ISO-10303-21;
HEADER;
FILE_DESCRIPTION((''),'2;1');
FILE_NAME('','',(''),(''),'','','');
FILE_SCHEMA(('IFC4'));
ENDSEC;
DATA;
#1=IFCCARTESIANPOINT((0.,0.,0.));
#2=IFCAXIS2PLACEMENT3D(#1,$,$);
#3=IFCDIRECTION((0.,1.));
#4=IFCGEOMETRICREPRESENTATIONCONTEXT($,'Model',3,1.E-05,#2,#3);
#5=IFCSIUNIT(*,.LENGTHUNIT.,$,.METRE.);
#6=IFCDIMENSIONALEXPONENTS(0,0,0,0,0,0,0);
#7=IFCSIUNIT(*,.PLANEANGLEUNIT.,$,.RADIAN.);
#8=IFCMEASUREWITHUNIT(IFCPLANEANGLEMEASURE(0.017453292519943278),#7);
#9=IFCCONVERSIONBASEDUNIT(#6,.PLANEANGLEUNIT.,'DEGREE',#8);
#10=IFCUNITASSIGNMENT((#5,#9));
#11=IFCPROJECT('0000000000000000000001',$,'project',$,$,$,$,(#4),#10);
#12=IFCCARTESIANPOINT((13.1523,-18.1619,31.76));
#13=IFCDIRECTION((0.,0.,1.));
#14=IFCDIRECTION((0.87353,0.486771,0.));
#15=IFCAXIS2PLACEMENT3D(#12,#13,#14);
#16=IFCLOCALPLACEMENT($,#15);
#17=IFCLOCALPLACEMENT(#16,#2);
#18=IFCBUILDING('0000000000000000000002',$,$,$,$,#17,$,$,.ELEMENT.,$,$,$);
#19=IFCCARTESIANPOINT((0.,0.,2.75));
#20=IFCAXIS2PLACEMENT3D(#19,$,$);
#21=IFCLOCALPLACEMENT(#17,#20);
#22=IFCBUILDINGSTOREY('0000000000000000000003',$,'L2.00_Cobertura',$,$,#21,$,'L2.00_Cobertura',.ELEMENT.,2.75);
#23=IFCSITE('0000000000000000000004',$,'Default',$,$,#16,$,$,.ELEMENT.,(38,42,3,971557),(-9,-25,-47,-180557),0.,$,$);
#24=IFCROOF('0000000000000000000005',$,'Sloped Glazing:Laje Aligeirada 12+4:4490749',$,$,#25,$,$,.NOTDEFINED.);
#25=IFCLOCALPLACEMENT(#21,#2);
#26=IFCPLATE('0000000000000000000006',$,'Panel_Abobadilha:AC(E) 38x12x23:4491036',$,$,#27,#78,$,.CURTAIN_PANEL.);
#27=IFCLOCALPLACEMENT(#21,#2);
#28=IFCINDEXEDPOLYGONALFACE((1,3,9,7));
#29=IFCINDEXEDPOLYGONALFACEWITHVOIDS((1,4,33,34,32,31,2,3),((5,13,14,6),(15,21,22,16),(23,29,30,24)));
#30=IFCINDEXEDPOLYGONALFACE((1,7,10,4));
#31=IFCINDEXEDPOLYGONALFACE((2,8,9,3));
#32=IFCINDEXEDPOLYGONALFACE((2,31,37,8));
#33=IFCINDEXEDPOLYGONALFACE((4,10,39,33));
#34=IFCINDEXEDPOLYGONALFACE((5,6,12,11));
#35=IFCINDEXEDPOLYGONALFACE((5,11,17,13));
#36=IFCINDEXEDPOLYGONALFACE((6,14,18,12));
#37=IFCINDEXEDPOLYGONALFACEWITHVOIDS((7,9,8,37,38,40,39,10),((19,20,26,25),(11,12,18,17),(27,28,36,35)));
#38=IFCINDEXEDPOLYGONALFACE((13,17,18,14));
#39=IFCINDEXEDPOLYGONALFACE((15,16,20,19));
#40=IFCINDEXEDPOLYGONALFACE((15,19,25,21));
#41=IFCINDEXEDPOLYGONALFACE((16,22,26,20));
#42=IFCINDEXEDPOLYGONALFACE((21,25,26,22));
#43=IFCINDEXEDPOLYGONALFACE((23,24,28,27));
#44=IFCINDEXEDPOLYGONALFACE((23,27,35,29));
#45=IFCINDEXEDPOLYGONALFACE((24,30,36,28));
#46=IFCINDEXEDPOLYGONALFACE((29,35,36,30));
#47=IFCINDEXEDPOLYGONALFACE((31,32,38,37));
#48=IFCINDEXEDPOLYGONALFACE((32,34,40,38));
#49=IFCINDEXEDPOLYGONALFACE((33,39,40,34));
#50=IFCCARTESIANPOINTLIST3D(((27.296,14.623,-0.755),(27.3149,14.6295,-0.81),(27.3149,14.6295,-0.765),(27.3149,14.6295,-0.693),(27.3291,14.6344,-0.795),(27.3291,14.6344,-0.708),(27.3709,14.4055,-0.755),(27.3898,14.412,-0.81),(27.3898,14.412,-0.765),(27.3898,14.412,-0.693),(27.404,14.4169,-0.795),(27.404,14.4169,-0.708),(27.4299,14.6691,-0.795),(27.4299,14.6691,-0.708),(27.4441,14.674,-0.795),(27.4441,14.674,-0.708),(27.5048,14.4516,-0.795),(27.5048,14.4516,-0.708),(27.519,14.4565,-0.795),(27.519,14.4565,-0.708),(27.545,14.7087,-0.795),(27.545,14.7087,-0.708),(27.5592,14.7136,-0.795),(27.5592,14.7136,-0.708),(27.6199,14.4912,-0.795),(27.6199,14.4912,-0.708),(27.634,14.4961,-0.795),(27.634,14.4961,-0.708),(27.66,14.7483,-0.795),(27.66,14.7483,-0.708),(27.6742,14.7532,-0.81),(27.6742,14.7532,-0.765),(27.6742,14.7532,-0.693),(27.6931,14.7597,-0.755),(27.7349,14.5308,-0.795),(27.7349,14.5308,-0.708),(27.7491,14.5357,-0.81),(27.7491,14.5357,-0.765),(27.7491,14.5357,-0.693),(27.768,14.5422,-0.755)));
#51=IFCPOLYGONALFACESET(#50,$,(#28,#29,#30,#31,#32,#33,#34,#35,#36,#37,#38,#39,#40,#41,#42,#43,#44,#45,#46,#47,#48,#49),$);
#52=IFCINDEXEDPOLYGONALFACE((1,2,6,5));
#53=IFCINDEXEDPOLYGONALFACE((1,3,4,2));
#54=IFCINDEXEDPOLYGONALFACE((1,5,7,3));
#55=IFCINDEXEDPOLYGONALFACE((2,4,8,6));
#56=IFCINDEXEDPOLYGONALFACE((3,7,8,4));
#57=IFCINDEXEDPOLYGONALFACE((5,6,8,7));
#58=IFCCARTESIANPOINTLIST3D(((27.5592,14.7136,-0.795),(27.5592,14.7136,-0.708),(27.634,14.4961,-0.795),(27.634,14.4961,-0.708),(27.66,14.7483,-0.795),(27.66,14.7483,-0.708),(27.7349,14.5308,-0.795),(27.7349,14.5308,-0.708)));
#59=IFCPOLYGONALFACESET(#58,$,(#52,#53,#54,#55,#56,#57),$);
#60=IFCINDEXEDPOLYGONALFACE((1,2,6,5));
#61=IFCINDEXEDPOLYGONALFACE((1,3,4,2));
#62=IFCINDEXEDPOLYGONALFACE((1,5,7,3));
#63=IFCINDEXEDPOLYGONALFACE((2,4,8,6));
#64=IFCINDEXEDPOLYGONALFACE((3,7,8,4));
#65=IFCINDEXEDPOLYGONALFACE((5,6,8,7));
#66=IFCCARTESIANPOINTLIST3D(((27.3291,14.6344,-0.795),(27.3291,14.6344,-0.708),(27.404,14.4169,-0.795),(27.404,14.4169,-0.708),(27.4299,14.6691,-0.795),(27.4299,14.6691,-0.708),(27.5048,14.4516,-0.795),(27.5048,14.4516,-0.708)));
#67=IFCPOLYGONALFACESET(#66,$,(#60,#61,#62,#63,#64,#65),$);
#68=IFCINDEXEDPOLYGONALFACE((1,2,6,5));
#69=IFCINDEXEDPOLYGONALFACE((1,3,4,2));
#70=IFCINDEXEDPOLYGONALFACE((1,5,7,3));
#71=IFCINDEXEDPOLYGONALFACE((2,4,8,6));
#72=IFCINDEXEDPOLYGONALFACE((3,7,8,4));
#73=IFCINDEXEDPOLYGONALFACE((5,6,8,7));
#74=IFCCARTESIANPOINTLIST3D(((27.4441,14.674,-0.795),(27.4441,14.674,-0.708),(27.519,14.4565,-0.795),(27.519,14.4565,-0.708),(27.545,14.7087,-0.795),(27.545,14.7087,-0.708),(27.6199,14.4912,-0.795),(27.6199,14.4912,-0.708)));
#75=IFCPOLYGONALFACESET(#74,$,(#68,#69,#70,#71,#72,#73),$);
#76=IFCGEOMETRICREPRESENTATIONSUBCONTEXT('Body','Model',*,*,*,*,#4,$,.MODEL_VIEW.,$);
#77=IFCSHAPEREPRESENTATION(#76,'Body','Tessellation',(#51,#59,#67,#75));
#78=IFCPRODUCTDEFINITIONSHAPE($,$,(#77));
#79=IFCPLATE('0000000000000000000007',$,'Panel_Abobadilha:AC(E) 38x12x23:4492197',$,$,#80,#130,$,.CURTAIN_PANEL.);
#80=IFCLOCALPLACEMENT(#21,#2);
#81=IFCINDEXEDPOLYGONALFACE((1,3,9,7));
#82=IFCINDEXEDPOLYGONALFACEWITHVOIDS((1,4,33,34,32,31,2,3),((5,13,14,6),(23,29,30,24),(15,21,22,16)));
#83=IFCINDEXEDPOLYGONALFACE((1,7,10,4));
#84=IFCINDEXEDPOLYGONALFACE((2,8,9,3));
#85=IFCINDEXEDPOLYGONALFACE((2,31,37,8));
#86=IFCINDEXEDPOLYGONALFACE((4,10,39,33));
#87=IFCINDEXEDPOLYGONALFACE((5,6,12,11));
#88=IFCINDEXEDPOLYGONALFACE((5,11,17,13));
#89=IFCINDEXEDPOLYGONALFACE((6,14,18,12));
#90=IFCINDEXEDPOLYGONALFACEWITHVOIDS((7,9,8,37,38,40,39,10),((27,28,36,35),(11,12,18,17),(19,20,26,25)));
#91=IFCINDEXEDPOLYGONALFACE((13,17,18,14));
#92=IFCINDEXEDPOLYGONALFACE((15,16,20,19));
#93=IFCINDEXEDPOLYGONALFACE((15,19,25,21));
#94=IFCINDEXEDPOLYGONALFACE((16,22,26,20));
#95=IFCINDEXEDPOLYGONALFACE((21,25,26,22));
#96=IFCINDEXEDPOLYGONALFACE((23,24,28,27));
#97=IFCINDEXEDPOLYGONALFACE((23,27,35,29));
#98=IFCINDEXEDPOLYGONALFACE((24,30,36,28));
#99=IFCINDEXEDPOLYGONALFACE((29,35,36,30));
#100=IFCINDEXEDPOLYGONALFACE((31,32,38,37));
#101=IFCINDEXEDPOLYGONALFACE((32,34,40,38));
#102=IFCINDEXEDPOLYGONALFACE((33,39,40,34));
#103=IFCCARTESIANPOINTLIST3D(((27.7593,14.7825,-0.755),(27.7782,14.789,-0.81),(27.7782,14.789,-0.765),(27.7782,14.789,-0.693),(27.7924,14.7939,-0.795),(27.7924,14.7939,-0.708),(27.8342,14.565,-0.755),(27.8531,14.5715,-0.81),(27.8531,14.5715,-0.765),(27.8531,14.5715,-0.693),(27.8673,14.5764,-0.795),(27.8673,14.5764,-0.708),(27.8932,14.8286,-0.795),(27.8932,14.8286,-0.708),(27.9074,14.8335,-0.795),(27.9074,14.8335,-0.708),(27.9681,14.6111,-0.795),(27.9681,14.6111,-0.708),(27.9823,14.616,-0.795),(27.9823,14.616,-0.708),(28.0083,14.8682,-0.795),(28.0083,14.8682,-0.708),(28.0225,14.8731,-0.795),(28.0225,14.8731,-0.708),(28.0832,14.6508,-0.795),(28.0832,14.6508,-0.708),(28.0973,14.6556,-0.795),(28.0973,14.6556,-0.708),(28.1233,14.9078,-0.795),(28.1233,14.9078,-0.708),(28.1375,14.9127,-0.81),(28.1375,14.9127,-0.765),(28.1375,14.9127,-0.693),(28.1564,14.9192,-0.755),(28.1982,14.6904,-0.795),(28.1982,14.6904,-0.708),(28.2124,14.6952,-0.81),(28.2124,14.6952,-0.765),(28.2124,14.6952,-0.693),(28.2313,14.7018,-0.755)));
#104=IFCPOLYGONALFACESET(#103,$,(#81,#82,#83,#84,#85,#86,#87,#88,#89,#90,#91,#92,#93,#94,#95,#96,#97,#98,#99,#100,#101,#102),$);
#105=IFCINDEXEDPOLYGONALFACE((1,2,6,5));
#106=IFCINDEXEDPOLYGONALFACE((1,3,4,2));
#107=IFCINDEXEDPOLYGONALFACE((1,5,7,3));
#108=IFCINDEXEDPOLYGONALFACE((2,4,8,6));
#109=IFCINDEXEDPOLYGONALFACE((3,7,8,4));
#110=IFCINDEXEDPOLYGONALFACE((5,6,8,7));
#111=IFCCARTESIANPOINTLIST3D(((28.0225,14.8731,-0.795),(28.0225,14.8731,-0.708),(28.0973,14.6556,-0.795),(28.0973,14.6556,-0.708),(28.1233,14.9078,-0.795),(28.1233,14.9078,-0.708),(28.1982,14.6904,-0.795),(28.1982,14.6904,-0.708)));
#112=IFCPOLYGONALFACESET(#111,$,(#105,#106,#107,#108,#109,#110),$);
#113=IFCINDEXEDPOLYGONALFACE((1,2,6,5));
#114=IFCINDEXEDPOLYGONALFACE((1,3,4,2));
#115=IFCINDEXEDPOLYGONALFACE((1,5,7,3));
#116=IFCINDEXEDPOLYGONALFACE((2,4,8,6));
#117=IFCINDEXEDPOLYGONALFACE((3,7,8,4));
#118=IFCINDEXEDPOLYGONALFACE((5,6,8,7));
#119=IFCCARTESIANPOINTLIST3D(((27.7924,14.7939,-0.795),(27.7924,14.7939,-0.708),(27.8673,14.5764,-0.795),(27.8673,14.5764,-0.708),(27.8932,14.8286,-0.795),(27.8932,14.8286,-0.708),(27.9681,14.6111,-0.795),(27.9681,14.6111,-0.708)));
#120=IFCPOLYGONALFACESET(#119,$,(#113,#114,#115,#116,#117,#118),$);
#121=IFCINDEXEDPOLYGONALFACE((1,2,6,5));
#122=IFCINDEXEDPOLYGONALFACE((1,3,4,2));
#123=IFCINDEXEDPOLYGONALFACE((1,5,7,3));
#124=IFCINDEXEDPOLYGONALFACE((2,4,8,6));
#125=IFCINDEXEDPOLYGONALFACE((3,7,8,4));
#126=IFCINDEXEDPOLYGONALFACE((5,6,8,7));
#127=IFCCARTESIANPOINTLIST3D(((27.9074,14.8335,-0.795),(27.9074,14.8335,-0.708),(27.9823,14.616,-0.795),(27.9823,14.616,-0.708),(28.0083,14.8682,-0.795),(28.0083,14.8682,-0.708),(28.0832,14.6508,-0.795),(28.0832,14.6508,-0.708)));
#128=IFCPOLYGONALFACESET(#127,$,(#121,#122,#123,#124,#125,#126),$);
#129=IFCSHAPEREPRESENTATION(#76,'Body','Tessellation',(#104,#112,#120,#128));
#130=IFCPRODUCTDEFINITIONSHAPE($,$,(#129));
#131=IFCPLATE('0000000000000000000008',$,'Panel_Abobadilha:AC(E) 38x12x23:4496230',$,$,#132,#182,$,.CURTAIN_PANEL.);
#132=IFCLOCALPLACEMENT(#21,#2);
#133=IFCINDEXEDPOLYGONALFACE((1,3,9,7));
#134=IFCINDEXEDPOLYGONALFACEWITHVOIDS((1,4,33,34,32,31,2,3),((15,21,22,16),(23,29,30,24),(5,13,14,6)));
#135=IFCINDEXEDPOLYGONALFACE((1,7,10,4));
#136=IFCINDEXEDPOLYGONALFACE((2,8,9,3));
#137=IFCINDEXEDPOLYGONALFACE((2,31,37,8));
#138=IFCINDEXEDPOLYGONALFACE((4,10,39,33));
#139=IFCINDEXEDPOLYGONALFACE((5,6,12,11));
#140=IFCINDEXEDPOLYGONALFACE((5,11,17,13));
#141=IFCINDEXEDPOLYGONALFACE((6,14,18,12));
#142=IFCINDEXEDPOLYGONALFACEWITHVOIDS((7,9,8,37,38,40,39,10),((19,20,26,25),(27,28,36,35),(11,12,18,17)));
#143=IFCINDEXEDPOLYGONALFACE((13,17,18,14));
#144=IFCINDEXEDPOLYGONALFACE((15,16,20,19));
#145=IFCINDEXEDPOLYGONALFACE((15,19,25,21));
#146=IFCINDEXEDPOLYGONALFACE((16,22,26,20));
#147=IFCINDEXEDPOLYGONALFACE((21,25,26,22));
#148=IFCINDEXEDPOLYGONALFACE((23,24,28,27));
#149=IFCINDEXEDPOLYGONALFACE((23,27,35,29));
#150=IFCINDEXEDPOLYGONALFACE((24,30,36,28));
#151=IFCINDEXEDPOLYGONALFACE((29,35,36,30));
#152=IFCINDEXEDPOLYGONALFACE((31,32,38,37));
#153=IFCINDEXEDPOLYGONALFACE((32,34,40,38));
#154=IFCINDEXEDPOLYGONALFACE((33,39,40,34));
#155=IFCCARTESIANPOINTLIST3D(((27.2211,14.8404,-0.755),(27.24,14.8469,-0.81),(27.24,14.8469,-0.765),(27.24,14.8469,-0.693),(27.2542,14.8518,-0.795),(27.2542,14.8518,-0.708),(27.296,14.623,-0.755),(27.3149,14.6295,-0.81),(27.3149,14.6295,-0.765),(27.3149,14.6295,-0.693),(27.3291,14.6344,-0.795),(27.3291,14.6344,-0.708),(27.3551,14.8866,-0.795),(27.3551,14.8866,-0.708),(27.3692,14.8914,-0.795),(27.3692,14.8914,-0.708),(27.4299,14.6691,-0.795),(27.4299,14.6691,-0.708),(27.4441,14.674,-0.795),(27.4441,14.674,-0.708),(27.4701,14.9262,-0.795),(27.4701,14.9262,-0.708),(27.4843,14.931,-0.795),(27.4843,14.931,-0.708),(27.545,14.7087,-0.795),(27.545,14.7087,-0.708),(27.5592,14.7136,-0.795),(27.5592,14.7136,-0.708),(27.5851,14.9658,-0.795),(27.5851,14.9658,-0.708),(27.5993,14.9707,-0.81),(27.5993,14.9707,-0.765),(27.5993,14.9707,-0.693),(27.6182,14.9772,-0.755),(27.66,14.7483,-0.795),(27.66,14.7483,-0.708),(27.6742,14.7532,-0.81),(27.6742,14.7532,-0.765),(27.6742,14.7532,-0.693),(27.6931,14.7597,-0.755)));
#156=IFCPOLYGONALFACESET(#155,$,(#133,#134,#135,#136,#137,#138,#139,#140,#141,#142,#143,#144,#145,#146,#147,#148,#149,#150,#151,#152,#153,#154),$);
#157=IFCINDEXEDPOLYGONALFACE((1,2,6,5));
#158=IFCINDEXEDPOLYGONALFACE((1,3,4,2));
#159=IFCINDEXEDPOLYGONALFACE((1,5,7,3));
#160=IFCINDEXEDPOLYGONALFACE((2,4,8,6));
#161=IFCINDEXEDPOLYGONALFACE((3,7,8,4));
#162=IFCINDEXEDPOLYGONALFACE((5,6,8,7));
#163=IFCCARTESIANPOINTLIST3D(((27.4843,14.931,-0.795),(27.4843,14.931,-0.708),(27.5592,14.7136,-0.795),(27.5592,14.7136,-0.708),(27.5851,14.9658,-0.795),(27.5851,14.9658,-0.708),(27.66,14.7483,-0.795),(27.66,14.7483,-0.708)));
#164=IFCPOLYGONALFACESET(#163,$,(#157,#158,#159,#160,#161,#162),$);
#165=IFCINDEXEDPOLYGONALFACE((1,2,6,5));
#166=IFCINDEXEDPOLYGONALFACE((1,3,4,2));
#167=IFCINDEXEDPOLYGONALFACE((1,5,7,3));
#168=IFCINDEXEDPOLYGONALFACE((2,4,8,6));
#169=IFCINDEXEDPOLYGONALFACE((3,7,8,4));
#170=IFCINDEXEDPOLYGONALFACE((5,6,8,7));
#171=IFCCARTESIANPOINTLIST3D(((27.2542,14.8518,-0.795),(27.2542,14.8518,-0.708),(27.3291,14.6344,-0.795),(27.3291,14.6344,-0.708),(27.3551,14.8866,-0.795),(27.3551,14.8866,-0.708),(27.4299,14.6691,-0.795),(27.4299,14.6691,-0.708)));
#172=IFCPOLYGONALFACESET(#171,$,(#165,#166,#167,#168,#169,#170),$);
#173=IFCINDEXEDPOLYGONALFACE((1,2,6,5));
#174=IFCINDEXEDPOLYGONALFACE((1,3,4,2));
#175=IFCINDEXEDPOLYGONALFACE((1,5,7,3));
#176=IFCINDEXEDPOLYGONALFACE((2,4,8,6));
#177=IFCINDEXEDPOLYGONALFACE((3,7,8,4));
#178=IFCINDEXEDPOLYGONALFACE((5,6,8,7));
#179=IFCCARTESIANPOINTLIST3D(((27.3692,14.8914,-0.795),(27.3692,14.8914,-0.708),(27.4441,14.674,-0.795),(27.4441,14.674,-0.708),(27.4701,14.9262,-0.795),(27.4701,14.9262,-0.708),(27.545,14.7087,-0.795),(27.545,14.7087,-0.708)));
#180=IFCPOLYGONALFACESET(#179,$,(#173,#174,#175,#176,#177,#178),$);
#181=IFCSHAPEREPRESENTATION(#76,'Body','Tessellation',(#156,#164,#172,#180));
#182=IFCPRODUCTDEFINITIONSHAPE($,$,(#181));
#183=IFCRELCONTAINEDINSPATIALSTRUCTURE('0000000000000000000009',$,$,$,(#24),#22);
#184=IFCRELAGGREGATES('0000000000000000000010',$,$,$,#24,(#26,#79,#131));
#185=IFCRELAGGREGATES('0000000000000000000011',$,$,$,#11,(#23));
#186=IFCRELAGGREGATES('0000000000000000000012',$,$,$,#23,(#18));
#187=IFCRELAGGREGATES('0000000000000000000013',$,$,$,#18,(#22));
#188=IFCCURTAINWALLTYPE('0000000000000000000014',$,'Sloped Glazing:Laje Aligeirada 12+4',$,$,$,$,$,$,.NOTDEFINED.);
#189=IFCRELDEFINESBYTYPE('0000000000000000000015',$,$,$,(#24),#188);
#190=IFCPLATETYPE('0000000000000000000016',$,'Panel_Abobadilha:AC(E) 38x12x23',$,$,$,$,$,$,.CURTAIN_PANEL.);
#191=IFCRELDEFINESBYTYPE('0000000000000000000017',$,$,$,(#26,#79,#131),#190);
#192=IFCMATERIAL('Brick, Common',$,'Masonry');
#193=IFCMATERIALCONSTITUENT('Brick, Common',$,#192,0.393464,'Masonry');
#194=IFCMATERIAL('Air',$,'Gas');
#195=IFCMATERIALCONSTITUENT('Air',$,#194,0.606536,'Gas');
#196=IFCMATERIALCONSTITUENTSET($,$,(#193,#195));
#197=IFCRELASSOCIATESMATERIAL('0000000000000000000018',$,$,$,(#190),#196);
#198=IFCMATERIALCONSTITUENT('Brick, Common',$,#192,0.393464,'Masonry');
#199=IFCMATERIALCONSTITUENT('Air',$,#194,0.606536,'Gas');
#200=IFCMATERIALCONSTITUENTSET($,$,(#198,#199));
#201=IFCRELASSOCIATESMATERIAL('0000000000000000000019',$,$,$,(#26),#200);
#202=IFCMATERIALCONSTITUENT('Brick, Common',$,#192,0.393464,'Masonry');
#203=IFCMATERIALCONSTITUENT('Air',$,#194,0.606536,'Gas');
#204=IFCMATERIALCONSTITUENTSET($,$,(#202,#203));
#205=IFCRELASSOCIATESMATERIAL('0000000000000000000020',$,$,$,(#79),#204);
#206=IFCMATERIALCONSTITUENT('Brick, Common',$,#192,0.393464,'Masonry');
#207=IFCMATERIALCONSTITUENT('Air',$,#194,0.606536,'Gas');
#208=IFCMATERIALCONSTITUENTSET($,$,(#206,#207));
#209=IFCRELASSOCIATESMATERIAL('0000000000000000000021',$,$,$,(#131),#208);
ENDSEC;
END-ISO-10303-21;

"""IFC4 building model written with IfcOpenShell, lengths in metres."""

from ifc_helpers import new_model, entity, si_unit, converted_unit, direction, frame, origin, place, context, subcontext, project, spatial, indexed_curve, outline, extrude, source, transform, mapped, material, constituent, constituent_set, type_object, type_shapes, element, aggregate, save


model = new_model("IFC4")

# Units and contexts
model_context = context("Model", 3, precision=1e-05, world=origin(), true_north=direction((0.0, 1.0)))
body_context = subcontext(model_context, "Body", "Model", "MODEL_VIEW")
ifc_project = project(units=[si_unit("LENGTHUNIT", "METRE"), converted_unit("PLANEANGLEUNIT", "DEGREE", entity("IfcPlaneAngleMeasure", 0.017453292519943278), si_unit("PLANEANGLEUNIT", "RADIAN"), dimensions=[0, 0, 0, 0, 0, 0, 0])], contexts=[model_context])

# Site, building, storey
site_placement = place(None, frame((13.1523, -18.1619, 31.76), z_axis=(0.0, 0.0, 1.0), x_axis=(0.87353, 0.486771, 0.0)))
site = spatial("IfcSite", under=ifc_project, at=site_placement, Name="Default", CompositionType="ELEMENT", RefLatitude=(38, 42, 3, 971557), RefLongitude=(-9, -25, -47, -180557), RefElevation=0.0)
building_placement = place(site_placement, origin())
building = spatial("IfcBuilding", under=site, at=building_placement, CompositionType="ELEMENT")
storey_placement = place(building_placement, frame((0.0, 0.0, 2.75)))
storey = spatial("IfcBuildingStorey", under=building, at=storey_placement, Name="L2.00_Cobertura", LongName="L2.00_Cobertura", CompositionType="ELEMENT", Elevation=2.75)

# Roof, plates
curtain_wall_type = type_object("IfcCurtainWallType", Name="Sloped Glazing:Laje Aligeirada 12+4", PredefinedType="NOTDEFINED")
roof_placement = place(storey_placement, frame((0.0, 0.0, -2.75)))
roof = element("IfcRoof", 1, at=roof_placement, inside=storey, type_object=curtain_wall_type, Name="Sloped Glazing:Laje Aligeirada 12+4:4490749", PredefinedType="NOTDEFINED")
ifc_material_1 = material(Name="Brick, Common", Category="Masonry")
ifc_material_2 = material(Name="Air", Category="Gas")
ifc_constituent_1 = constituent(ifc_material_1, Name="Brick, Common", Category="Masonry", fraction=0.393464)
ifc_constituent_2 = constituent(ifc_material_2, Name="Air", Category="Gas", fraction=0.606536)
ifc_constituent_set_1 = constituent_set(constituents=[ifc_constituent_1, ifc_constituent_2])
plate_type = type_object("IfcPlateType", Name="Panel_Abobadilha:AC(E) 38x12x23", PredefinedType="CURTAIN_PANEL", material=ifc_constituent_set_1)
shared_shape_1 = source(origin(), body_context, "Body", "SweptSolid", [
    extrude(outline(indexed_curve([(-0.19, -0.0543), (0.19, -0.0543), (0.19, -0.0093), (0.21, 0.0007), (0.19, 0.0628), (-0.19, 0.0628), (-0.21, 0.0007), (-0.19, -0.0093), (-0.19, -0.0543)], self_intersect=False), holes=[indexed_curve([(-0.0683, 0.0477), (-0.0683, -0.0393), (-0.175, -0.0393), (-0.175, 0.0477), (-0.0683, 0.0477)], self_intersect=False), indexed_curve([(0.0533, 0.0477), (0.0533, -0.0393), (-0.0533, -0.0393), (-0.0533, 0.0477), (0.0533, 0.0477)], self_intersect=False), indexed_curve([(0.175, 0.0477), (0.175, -0.0393), (0.0683, -0.0393), (0.0683, 0.0477), (0.175, 0.0477)], self_intersect=False)]), frame((0.0, 0.0543, 0.0)), (0.0, 0.0, 1.0), 0.23),
    extrude(outline(indexed_curve([(-0.0533, -0.0435), (0.0533, -0.0435), (0.0533, 0.0435), (-0.0533, 0.0435), (-0.0533, -0.0435)], self_intersect=False)), frame((0.1217, 0.0585, 0.0), z_axis=(0.0, 0.0, 1.0), x_axis=(-1.0, 0.0, 0.0)), (0.0, 0.0, 1.0), 0.23),
    extrude(outline(indexed_curve([(-0.0533, -0.0435), (0.0533, -0.0435), (0.0533, 0.0435), (-0.0533, 0.0435), (-0.0533, -0.0435)], self_intersect=False)), frame((-0.1217, 0.0585, 0.0), z_axis=(0.0, 0.0, 1.0), x_axis=(-1.0, 0.0, 0.0)), (0.0, 0.0, 1.0), 0.23),
    extrude(outline(indexed_curve([(-0.0533, -0.0435), (0.0533, -0.0435), (0.0533, 0.0435), (-0.0533, 0.0435), (-0.0533, -0.0435)], self_intersect=False)), frame((0.0, 0.0585, 0.0), z_axis=(0.0, 0.0, 1.0), x_axis=(-1.0, 0.0, 0.0)), (0.0, 0.0, 1.0), 0.23),
])
type_shapes(plate_type, [shared_shape_1])
ifc_constituent_3 = constituent(ifc_material_1, Name="Brick, Common", Category="Masonry", fraction=0.393464)
ifc_constituent_4 = constituent(ifc_material_2, Name="Air", Category="Gas", fraction=0.606536)
ifc_constituent_set_2 = constituent_set(constituents=[ifc_constituent_3, ifc_constituent_4])
plate_1_placement = place(roof_placement, frame((27.4946, 14.6913, 1.94), z_axis=(0.325568, -0.945519, 0.0), x_axis=(0.945519, 0.325568, 0.0)))
plate_1 = element("IfcPlate", 2, at=plate_1_placement, type_object=plate_type, material=ifc_constituent_set_2, Name="Panel_Abobadilha:AC(E) 38x12x23:4491036", PredefinedType="CURTAIN_PANEL", context=body_context, shape_type="MappedRepresentation", body=[
    mapped(shared_shape_1, transform((0.0, 0.0, 0.0), scale=1.0)),
])
ifc_constituent_5 = constituent(ifc_material_1, Name="Brick, Common", Category="Masonry", fraction=0.393464)
ifc_constituent_6 = constituent(ifc_material_2, Name="Air", Category="Gas", fraction=0.606536)
ifc_constituent_set_3 = constituent_set(constituents=[ifc_constituent_5, ifc_constituent_6])
plate_2_placement = place(roof_placement, frame((27.9579, 14.8509, 1.94), z_axis=(0.325568, -0.945519, 0.0), x_axis=(0.945519, 0.325568, 0.0)))
plate_2 = element("IfcPlate", 3, at=plate_2_placement, type_object=plate_type, material=ifc_constituent_set_3, Name="Panel_Abobadilha:AC(E) 38x12x23:4492197", PredefinedType="CURTAIN_PANEL", context=body_context, shape_type="MappedRepresentation", body=[
    mapped(shared_shape_1, transform((0.0, 0.0, 0.0), scale=1.0)),
])
ifc_constituent_7 = constituent(ifc_material_1, Name="Brick, Common", Category="Masonry", fraction=0.393464)
ifc_constituent_8 = constituent(ifc_material_2, Name="Air", Category="Gas", fraction=0.606536)
ifc_constituent_set_4 = constituent_set(constituents=[ifc_constituent_7, ifc_constituent_8])
plate_3_placement = place(roof_placement, frame((27.4197, 14.9088, 1.94), z_axis=(0.325568, -0.945519, 0.0), x_axis=(0.945519, 0.325568, 0.0)))
plate_3 = element("IfcPlate", 4, at=plate_3_placement, type_object=plate_type, material=ifc_constituent_set_4, Name="Panel_Abobadilha:AC(E) 38x12x23:4496230", PredefinedType="CURTAIN_PANEL", context=body_context, shape_type="MappedRepresentation", body=[
    mapped(shared_shape_1, transform((0.0, 0.0, 0.0), scale=1.0)),
])
aggregate(roof, [plate_1, plate_2, plate_3])

save(model, "model.ifc")
